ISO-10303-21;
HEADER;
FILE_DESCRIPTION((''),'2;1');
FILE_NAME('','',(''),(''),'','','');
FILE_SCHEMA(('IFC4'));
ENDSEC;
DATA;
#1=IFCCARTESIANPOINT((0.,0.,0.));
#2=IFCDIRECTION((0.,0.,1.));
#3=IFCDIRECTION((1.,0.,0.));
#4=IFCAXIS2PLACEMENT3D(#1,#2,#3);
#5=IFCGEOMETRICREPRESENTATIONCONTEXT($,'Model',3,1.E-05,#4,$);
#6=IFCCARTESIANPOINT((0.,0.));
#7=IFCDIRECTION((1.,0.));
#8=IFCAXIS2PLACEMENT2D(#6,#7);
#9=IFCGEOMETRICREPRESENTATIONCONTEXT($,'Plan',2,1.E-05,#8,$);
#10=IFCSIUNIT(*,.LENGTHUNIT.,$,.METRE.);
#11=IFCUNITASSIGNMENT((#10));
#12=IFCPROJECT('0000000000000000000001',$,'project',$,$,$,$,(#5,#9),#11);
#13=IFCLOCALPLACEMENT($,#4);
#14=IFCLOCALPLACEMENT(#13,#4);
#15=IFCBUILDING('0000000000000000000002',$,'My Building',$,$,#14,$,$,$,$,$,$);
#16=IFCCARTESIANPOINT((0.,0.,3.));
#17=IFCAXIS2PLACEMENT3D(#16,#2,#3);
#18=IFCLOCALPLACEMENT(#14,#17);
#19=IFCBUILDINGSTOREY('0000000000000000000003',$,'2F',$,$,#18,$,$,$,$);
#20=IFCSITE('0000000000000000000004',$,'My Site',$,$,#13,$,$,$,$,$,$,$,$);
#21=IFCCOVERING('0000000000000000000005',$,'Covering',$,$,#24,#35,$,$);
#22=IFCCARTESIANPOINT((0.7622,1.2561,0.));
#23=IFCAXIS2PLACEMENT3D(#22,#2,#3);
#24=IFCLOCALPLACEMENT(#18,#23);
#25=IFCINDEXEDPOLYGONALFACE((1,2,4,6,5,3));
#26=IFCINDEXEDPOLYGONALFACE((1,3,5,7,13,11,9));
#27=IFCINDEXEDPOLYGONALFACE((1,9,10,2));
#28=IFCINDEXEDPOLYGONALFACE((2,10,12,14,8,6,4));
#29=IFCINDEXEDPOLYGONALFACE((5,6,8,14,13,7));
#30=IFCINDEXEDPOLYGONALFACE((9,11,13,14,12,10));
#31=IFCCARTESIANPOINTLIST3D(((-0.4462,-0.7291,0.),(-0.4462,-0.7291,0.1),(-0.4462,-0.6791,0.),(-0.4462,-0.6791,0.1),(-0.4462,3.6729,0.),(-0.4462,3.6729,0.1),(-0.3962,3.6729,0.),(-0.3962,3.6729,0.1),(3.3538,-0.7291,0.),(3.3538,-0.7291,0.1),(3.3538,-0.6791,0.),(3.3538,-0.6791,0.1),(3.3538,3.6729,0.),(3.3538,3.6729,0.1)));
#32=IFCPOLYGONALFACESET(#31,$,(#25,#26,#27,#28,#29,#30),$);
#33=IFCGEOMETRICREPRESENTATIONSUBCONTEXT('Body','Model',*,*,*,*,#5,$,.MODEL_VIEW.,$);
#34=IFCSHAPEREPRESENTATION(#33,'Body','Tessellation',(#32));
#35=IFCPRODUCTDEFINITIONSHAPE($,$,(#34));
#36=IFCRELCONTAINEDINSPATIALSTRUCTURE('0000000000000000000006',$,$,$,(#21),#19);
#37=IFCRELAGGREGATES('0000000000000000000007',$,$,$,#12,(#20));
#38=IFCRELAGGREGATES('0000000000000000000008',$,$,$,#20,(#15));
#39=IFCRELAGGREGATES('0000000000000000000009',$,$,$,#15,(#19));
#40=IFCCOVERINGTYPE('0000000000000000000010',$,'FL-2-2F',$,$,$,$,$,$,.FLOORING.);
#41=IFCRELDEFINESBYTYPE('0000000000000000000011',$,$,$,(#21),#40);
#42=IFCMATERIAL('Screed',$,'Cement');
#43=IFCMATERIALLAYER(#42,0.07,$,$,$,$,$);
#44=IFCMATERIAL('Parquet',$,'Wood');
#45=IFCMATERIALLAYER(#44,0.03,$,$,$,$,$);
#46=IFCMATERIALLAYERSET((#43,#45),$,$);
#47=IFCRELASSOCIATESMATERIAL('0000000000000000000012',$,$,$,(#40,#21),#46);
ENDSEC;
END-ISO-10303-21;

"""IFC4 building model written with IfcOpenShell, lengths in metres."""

from ifc_helpers import new_model, si_unit, frame, origin_with_axes, origin_2d_with_axis, place, context, subcontext, project, spatial, line, indexed_curve, outline, extrude, material, layer, layer_set, layer_usage, type_object, element, save


model = new_model("IFC4")

# Units and contexts
model_context = context("Model", 3, precision=1e-05, world=origin_with_axes())
plan_context = context("Plan", 2, precision=1e-05, world=origin_2d_with_axis())
body_context_1 = subcontext(model_context, "Body", "Model", "MODEL_VIEW")
ifc_project = project(units=[si_unit("LENGTHUNIT", "METRE")], contexts=[model_context, plan_context])

# Site, building, storey
site_placement = place(None, origin_with_axes())
site = spatial("IfcSite", under=ifc_project, at=site_placement, Name="My Site")
building_placement = place(site_placement, origin_with_axes())
building = spatial("IfcBuilding", under=site, at=building_placement, Name="My Building")
storey_placement = place(building_placement, frame((0.0, 0.0, 3.0), z_axis=(0.0, 0.0, 1.0), x_axis=(1.0, 0.0, 0.0)))
storey = spatial("IfcBuildingStorey", under=building, at=storey_placement, Name="2F")

# Covering
ifc_material_1 = material(Name="Screed", Category="Cement")
ifc_layer_1 = layer(ifc_material_1, 0.07)
ifc_material_2 = material(Name="Parquet", Category="Wood")
ifc_layer_2 = layer(ifc_material_2, 0.03)
ifc_layer_set_1 = layer_set([ifc_layer_1, ifc_layer_2])
ifc_layer_usage_1 = layer_usage(ifc_layer_set_1, "AXIS3", "POSITIVE", 0.0)
covering_type = type_object("IfcCoveringType", Name="FL-2-2F", PredefinedType="FLOORING", material=ifc_layer_set_1)
covering_placement = place(storey_placement, frame((0.7622, 1.2561, 0.0), z_axis=(0.0, 0.0, 1.0), x_axis=(1.0, 0.0, 0.0)))
element("IfcCovering", 1, at=covering_placement, inside=storey, type_object=covering_type, material=ifc_layer_usage_1, Name="Covering", context=body_context_1, shape_type="SweptSolid", body=[
    extrude(outline(indexed_curve([(3.3538, 3.6729), (3.3538, -0.6791), (3.3538, -0.7291), (-0.4462, -0.7291), (-0.4462, -0.6791), (-0.4462, 3.6729), (-0.3962, 3.6729)], segments=[line(1, 2, 3, 4, 5, 6, 7, 1)])), origin_with_axes(), (0.0, 0.0, 1.0), 0.1),
])

save(model, "model.ifc")
